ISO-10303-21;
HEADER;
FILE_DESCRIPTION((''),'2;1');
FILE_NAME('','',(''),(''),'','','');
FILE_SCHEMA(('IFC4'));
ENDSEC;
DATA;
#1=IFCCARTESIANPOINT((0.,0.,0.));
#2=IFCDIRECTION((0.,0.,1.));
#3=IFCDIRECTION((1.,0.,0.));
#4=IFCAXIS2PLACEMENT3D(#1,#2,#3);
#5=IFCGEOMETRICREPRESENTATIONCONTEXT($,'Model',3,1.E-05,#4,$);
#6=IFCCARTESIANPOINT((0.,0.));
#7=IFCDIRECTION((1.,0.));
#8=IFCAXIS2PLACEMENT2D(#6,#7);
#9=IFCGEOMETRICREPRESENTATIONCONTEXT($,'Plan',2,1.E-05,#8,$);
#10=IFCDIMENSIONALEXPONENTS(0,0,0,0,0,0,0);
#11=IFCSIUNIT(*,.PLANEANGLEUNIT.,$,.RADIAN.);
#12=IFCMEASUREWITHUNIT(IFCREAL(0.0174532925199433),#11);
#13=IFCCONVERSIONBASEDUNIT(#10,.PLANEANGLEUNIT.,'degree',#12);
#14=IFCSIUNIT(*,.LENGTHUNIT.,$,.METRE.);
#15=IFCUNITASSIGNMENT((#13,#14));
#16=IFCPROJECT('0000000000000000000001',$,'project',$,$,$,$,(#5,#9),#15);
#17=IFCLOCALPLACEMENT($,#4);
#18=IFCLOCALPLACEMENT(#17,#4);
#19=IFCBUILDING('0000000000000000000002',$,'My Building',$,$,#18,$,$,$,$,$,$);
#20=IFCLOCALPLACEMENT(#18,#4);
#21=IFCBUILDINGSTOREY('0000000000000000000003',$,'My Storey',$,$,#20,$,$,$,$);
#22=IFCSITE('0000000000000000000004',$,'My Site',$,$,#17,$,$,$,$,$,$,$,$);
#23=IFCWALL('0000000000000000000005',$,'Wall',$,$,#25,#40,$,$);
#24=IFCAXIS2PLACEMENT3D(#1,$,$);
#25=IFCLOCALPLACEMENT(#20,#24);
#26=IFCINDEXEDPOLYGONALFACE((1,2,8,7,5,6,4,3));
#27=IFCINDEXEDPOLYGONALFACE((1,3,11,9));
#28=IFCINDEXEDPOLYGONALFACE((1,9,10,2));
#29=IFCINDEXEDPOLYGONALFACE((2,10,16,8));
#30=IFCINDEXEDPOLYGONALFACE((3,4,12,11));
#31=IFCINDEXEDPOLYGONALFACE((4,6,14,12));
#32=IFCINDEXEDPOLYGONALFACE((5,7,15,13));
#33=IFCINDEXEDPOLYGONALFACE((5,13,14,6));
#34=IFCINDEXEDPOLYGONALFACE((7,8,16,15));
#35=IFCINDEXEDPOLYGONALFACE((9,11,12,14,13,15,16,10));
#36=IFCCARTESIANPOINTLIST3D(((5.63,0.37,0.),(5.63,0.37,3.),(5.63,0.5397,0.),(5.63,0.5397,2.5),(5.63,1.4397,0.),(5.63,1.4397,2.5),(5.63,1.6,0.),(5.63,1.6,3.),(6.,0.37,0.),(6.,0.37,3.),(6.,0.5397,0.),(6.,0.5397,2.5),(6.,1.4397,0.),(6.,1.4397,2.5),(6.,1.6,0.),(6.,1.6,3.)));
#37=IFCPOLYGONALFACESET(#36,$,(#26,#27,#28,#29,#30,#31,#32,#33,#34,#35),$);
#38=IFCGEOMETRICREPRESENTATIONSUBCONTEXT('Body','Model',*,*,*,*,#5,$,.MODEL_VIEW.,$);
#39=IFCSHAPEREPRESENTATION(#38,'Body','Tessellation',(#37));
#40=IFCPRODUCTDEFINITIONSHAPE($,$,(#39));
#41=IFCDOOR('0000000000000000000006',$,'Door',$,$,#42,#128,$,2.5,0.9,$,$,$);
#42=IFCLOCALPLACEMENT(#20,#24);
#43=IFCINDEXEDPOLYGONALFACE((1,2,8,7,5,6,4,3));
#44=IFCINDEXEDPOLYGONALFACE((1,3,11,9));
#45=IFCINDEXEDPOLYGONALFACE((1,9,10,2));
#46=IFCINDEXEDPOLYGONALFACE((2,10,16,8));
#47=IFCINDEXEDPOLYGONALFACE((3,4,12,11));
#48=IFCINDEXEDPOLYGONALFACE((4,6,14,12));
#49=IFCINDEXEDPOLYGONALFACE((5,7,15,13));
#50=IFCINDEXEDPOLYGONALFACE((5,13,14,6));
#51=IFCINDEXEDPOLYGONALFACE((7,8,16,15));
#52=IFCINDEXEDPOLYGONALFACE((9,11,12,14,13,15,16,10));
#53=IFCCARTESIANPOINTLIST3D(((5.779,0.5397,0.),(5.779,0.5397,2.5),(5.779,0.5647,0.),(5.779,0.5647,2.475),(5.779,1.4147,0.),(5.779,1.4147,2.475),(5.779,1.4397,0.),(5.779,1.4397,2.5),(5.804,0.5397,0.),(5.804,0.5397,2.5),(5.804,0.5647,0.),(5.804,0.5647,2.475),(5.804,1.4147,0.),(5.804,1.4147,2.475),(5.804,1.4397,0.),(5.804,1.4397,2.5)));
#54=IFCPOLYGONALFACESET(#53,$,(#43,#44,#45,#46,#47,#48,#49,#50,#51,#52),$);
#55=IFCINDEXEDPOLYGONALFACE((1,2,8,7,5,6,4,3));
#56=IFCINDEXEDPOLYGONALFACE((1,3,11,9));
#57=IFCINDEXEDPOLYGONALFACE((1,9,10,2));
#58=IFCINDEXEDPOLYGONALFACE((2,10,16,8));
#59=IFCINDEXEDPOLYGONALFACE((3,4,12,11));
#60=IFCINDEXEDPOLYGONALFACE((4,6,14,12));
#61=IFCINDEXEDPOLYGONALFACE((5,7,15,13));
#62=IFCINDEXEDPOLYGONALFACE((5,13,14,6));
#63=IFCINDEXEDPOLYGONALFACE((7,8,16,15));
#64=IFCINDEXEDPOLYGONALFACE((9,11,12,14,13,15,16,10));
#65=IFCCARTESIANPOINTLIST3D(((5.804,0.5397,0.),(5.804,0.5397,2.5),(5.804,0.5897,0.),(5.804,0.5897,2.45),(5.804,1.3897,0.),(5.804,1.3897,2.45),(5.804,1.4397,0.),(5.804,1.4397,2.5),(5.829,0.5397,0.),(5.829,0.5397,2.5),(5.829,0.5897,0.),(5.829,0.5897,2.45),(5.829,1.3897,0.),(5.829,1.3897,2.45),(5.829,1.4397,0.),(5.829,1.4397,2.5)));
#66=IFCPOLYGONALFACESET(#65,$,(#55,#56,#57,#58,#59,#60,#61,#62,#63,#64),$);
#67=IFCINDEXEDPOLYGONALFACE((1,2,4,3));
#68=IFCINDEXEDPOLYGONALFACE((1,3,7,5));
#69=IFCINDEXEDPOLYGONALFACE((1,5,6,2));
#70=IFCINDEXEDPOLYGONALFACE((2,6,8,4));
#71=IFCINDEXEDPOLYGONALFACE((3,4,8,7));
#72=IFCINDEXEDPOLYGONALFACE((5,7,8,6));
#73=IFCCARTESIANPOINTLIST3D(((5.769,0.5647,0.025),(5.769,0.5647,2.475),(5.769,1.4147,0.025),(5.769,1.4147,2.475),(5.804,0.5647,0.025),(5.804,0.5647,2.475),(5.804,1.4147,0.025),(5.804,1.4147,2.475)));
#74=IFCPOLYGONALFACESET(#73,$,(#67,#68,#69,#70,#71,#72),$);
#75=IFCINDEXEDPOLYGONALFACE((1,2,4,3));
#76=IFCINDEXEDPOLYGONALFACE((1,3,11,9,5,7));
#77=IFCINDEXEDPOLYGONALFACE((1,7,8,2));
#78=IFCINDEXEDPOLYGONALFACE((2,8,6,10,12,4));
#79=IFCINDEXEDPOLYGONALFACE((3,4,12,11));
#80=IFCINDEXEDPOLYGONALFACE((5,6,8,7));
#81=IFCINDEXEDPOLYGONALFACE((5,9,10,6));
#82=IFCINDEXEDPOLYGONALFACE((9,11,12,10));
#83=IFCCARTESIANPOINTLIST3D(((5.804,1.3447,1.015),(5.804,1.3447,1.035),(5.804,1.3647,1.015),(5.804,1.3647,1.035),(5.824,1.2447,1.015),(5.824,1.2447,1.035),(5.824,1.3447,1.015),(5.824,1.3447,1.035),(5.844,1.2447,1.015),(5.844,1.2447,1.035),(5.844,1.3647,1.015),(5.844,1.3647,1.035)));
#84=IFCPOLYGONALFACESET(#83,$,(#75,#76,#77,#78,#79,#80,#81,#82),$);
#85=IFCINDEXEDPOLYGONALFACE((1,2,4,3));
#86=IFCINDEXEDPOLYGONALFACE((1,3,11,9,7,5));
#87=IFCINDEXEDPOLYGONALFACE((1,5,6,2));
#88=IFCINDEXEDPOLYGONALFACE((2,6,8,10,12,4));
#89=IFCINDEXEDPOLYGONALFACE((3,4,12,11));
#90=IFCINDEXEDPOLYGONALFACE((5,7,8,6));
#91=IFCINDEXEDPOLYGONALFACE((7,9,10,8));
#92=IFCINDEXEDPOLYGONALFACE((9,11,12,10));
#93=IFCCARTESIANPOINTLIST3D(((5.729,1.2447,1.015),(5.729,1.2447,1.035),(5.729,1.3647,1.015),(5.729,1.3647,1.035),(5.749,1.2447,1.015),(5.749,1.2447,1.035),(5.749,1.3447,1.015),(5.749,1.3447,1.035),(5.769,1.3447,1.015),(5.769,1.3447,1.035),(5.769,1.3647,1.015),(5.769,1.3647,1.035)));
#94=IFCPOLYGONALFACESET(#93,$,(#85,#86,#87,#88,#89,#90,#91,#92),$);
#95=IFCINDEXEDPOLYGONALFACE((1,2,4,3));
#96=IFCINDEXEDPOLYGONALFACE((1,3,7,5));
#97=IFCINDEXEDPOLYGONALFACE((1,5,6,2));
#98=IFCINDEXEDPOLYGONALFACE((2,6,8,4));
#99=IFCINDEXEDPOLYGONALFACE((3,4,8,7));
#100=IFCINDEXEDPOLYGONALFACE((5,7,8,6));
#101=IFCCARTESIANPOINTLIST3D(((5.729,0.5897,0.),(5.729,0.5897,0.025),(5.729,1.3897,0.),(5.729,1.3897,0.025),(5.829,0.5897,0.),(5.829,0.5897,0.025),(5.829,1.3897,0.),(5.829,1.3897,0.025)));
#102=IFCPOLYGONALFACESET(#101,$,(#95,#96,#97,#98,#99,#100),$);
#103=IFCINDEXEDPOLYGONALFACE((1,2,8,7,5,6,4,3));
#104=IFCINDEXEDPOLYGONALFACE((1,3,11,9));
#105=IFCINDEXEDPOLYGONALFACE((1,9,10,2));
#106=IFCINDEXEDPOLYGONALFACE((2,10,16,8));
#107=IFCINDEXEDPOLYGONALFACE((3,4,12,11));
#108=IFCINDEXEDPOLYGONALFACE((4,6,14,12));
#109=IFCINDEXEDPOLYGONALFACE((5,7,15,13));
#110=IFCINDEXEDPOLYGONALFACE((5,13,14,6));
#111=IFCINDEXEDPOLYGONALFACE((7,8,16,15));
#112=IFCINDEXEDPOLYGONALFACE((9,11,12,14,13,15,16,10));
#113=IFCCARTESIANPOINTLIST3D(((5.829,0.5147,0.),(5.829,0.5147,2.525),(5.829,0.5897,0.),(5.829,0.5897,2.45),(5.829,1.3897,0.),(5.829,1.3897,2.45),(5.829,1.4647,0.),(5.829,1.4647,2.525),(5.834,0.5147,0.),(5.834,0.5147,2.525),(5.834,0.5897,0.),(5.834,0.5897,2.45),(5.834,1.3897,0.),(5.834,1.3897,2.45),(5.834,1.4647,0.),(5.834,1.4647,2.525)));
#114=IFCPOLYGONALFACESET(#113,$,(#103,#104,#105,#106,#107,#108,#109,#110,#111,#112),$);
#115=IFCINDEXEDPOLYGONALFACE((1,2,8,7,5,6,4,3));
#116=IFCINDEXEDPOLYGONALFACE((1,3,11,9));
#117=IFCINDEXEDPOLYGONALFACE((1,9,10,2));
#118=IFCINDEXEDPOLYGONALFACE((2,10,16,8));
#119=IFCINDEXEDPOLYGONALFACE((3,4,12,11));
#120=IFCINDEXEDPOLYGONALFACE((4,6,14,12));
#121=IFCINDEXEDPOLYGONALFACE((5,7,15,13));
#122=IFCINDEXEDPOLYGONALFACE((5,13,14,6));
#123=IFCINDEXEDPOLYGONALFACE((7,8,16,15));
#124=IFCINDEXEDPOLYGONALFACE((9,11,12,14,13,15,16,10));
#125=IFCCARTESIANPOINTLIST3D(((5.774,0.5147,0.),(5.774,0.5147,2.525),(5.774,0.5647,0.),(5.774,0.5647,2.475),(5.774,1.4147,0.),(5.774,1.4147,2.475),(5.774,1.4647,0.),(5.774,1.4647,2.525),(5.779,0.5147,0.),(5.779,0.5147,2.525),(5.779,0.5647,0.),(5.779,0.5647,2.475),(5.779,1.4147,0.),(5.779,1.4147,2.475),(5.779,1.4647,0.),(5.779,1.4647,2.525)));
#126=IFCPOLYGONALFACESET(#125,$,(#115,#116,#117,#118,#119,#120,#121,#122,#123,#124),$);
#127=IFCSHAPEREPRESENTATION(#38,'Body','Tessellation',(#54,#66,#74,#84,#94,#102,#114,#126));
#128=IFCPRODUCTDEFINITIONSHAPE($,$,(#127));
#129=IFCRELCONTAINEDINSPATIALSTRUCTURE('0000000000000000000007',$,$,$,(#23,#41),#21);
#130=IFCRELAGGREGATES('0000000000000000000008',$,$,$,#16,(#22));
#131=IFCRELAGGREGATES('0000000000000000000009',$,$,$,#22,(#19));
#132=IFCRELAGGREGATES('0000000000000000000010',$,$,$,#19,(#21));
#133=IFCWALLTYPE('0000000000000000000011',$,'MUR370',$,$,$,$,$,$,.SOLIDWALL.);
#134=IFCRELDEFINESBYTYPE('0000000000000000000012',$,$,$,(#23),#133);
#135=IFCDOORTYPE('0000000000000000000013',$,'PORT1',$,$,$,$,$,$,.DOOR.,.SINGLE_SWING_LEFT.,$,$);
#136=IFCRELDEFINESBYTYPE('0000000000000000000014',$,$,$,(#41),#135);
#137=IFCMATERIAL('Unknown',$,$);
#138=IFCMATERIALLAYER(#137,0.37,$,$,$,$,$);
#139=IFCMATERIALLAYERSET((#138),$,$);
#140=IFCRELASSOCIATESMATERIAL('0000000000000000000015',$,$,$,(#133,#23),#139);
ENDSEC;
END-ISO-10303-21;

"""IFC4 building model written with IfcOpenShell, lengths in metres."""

from ifc_helpers import new_model, entity, si_unit, converted_unit, frame, origin_with_axes, origin_2d_with_axis, place, context, subcontext, project, spatial, line, indexed_curve, outline, extrude, shape, source, transform, mapped, material, layer, layer_set, layer_usage, type_object, type_shapes, element, fill, save


model = new_model("IFC4")

# Units and contexts
model_context = context("Model", 3, precision=1e-05, world=origin_with_axes())
plan_context = context("Plan", 2, precision=1e-05, world=origin_2d_with_axis())
body_context_1 = subcontext(model_context, "Body", "Model", "MODEL_VIEW")
body_context_2 = subcontext(plan_context, "Body", "Plan", "PLAN_VIEW")
ifc_project = project(units=[converted_unit("PLANEANGLEUNIT", "degree", entity("IfcReal", 0.0174532925199433), si_unit("PLANEANGLEUNIT", "RADIAN"), dimensions=[0, 0, 0, 0, 0, 0, 0]), si_unit("LENGTHUNIT", "METRE")], contexts=[model_context, plan_context])

# Site, building, storey
site_placement = place(None, origin_with_axes())
site = spatial("IfcSite", under=ifc_project, at=site_placement, Name="My Site")
building_placement = place(site_placement, origin_with_axes())
building = spatial("IfcBuilding", under=site, at=building_placement, Name="My Building")
storey_placement = place(building_placement, origin_with_axes())
storey = spatial("IfcBuildingStorey", under=building, at=storey_placement, Name="My Storey")

# Shared definitions
ifc_material = material(Name="Unknown")

# Shared definitions
ifc_layer_1 = layer(ifc_material, 0.37)
ifc_layer_set_1 = layer_set([ifc_layer_1])
wall_type_1 = type_object("IfcWallType", Name="MUR370", PredefinedType="SOLIDWALL", material=ifc_layer_set_1)

# Wall, opening, door
ifc_layer_usage_1 = layer_usage(ifc_layer_set_1, "AXIS2", "POSITIVE", 0.0)
wall_1_placement = place(storey_placement, frame((6.0, 0.37, 0.0), z_axis=(0.0, 0.0, 1.0), x_axis=(0.0, 1.0, 0.0)))
wall_1 = element("IfcWall", 1, at=wall_1_placement, inside=storey, type_object=wall_type_1, material=ifc_layer_usage_1, Name="Wall", context=body_context_1, shape_type="SweptSolid", body=[
    extrude(outline(indexed_curve([(0.0, 0.0), (0.0, 0.37), (1.23, 0.37), (1.23, 0.0), (0.0, 0.0)], self_intersect=False)), origin_with_axes(), (0.0, 0.0, 1.0), 3.0),
])
shared_shape_1 = source(origin_with_axes(), body_context_1, "Body", "SweptSolid", [
    extrude(outline(indexed_curve([(0.0, 0.0), (0.9, 0.0), (0.9, 2.5), (0.0, 2.5)], segments=[line(1, 2, 3, 4, 1)])), frame((0.0, -0.6, 0.0), z_axis=(0.0, -1.0, 0.0), x_axis=(1.0, 0.0, 0.0)), (0.0, 0.0, -1.0), 1.2),
])
opening_1_placement = place(wall_1_placement, frame((0.1697, 0.0, 0.0), z_axis=(0.0, 0.0, 1.0), x_axis=(1.0, 0.0, 0.0)))
opening_1 = element("IfcOpeningElement", 2, at=opening_1_placement, cuts=wall_1, PredefinedType="OPENING", context=body_context_1, shape_type="MappedRepresentation", body=[
    mapped(shared_shape_1, transform((0.0, 0.0, 0.0), x_axis=(1.0, 0.0, 0.0), y_axis=(0.0, 1.0, 0.0), z_axis=(0.0, 0.0, 1.0), scale=1.0)),
])
door_type_1 = type_object("IfcDoorType", Name="PORT1", OperationType="SINGLE_SWING_LEFT", PredefinedType="DOOR")
shared_shape_2 = source(origin_with_axes(), body_context_1, "Body", "SweptSolid", [
    extrude(outline(indexed_curve([(0.0, 0.0), (0.0, 2.5), (0.9, 2.5), (0.9, 0.0), (0.875, 0.0), (0.875, 2.475), (0.025, 2.475), (0.025, 0.0)], segments=[line(1, 2, 3, 4, 5, 6, 7, 8, 1)])), frame((0.0, 0.025, 0.0), z_axis=(0.0, -1.0, 0.0), x_axis=(1.0, 0.0, 0.0)), (0.0, 0.0, -1.0), 0.025),
    extrude(outline(indexed_curve([(0.0, 0.0), (0.0, 2.5), (0.9, 2.5), (0.9, 0.0), (0.85, 0.0), (0.85, 2.45), (0.05, 2.45), (0.05, 0.0)], segments=[line(1, 2, 3, 4, 5, 6, 7, 8, 1)])), frame((0.0, 0.0, 0.0), z_axis=(0.0, -1.0, 0.0), x_axis=(1.0, 0.0, 0.0)), (0.0, 0.0, -1.0), 0.025),
    extrude(outline(indexed_curve([(0.0, 0.0), (0.85, 0.0), (0.85, 0.035), (0.0, 0.035)], segments=[line(1, 2, 3, 4, 1)])), frame((0.025, 0.025, 0.025), z_axis=(0.0, 0.0, 1.0), x_axis=(1.0, 0.0, 0.0)), (0.0, 0.0, 1.0), 2.45),
    extrude(outline(indexed_curve([(0.0, 0.0), (0.0, -0.04), (-0.12, -0.04), (-0.12, -0.02), (-0.02, -0.02), (-0.02, 0.0)], segments=[line(1, 2, 3, 4, 5, 6, 1)])), frame((0.825, 0.025, 1.015), z_axis=(0.0, 0.0, 1.0), x_axis=(1.0, 0.0, 0.0)), (0.0, 0.0, 1.0), 0.02),
    extrude(outline(indexed_curve([(0.0, 0.0), (0.0, 0.04), (-0.12, 0.04), (-0.12, 0.02), (-0.02, 0.02), (-0.02, 0.0)], segments=[line(1, 2, 3, 4, 5, 6, 1)])), frame((0.825, 0.06, 1.015), z_axis=(0.0, 0.0, 1.0), x_axis=(1.0, 0.0, 0.0)), (0.0, 0.0, 1.0), 0.02),
    extrude(outline(indexed_curve([(0.0, 0.0), (0.8, 0.0), (0.8, 0.1), (0.0, 0.1)], segments=[line(1, 2, 3, 4, 1)])), frame((0.05, 0.0, 0.0), z_axis=(0.0, 0.0, 1.0), x_axis=(1.0, 0.0, 0.0)), (0.0, 0.0, 1.0), 0.025),
    extrude(outline(indexed_curve([(0.0, 0.0), (0.0, 2.525), (0.95, 2.525), (0.95, 0.0), (0.875, 0.0), (0.875, 2.45), (0.075, 2.45), (0.075, 0.0)], segments=[line(1, 2, 3, 4, 5, 6, 7, 8, 1)])), frame((-0.025, -0.005, 0.0), z_axis=(0.0, -1.0, 0.0), x_axis=(1.0, 0.0, 0.0)), (0.0, 0.0, -1.0), 0.005),
    extrude(outline(indexed_curve([(0.0, 0.0), (0.0, 2.525), (0.95, 2.525), (0.95, 0.0), (0.9, 0.0), (0.9, 2.475), (0.05, 2.475), (0.05, 0.0)], segments=[line(1, 2, 3, 4, 5, 6, 7, 8, 1)])), frame((-0.025, 0.05, 0.0), z_axis=(0.0, -1.0, 0.0), x_axis=(1.0, 0.0, 0.0)), (0.0, 0.0, -1.0), 0.005),
])
shared_shape_3 = source(origin_with_axes(), body_context_2, "Body", "Curve2D", [
    entity("IfcIndexedPolyCurve", entity("IfcCartesianPointList2D", [[0.0, 0.0], [0.0, 0.05], [0.025, 0.05], [0.025, 0.025], [0.05, 0.025], [0.05, 0.0]]), [entity("IfcLineIndex", [1, 2, 3, 4, 5, 6, 1])]),
    entity("IfcIndexedPolyCurve", entity("IfcCartesianPointList2D", [[0.9, 0.0], [0.9, 0.05], [0.875, 0.05], [0.875, 0.025], [0.85, 0.025], [0.85, 0.0]]), [entity("IfcLineIndex", [1, 2, 3, 4, 5, 6, 1])]),
    entity("IfcTrimmedCurve", entity("IfcEllipse", entity("IfcAxis2Placement2D", entity("IfcCartesianPoint", [0.06, 0.05]), entity("IfcDirection", [1.0, 0.0])), 0.815, 0.85), [entity("IfcCartesianPoint", [0.875, 0.05])], [entity("IfcCartesianPoint", [0.06, 0.9])], True, "CARTESIAN"),
    entity("IfcIndexedPolyCurve", entity("IfcCartesianPointList2D", [[0.025, 0.05], [0.06, 0.05], [0.06, 0.9], [0.025, 0.9]]), [entity("IfcLineIndex", [1, 2, 3, 4, 1])]),
])
type_shapes(door_type_1, [shared_shape_2, shared_shape_3])
door_1_placement = place(opening_1_placement, frame((0.0, 0.171, 0.0), z_axis=(0.0, 0.0, 1.0), x_axis=(1.0, 0.0, 0.0)))
door_1 = element("IfcDoor", 3, at=door_1_placement, inside=storey, type_object=door_type_1, Name="Door", OverallHeight=2.5, OverallWidth=0.9, shapes=[
    shape(body_context_1, "Body", "MappedRepresentation", [mapped(shared_shape_2, transform((0.0, 0.0, 0.0), x_axis=(1.0, 0.0, 0.0), y_axis=(0.0, 1.0, 0.0), z_axis=(0.0, 0.0, 1.0), scale=1.0))]),
    shape(body_context_2, "Body", "MappedRepresentation", [mapped(shared_shape_3, transform((0.0, 0.0, 0.0), x_axis=(1.0, 0.0, 0.0), y_axis=(0.0, 1.0, 0.0), z_axis=(0.0, 0.0, 1.0), scale=1.0))]),
])
fill(opening_1, door_1)

save(model, "model.ifc")
